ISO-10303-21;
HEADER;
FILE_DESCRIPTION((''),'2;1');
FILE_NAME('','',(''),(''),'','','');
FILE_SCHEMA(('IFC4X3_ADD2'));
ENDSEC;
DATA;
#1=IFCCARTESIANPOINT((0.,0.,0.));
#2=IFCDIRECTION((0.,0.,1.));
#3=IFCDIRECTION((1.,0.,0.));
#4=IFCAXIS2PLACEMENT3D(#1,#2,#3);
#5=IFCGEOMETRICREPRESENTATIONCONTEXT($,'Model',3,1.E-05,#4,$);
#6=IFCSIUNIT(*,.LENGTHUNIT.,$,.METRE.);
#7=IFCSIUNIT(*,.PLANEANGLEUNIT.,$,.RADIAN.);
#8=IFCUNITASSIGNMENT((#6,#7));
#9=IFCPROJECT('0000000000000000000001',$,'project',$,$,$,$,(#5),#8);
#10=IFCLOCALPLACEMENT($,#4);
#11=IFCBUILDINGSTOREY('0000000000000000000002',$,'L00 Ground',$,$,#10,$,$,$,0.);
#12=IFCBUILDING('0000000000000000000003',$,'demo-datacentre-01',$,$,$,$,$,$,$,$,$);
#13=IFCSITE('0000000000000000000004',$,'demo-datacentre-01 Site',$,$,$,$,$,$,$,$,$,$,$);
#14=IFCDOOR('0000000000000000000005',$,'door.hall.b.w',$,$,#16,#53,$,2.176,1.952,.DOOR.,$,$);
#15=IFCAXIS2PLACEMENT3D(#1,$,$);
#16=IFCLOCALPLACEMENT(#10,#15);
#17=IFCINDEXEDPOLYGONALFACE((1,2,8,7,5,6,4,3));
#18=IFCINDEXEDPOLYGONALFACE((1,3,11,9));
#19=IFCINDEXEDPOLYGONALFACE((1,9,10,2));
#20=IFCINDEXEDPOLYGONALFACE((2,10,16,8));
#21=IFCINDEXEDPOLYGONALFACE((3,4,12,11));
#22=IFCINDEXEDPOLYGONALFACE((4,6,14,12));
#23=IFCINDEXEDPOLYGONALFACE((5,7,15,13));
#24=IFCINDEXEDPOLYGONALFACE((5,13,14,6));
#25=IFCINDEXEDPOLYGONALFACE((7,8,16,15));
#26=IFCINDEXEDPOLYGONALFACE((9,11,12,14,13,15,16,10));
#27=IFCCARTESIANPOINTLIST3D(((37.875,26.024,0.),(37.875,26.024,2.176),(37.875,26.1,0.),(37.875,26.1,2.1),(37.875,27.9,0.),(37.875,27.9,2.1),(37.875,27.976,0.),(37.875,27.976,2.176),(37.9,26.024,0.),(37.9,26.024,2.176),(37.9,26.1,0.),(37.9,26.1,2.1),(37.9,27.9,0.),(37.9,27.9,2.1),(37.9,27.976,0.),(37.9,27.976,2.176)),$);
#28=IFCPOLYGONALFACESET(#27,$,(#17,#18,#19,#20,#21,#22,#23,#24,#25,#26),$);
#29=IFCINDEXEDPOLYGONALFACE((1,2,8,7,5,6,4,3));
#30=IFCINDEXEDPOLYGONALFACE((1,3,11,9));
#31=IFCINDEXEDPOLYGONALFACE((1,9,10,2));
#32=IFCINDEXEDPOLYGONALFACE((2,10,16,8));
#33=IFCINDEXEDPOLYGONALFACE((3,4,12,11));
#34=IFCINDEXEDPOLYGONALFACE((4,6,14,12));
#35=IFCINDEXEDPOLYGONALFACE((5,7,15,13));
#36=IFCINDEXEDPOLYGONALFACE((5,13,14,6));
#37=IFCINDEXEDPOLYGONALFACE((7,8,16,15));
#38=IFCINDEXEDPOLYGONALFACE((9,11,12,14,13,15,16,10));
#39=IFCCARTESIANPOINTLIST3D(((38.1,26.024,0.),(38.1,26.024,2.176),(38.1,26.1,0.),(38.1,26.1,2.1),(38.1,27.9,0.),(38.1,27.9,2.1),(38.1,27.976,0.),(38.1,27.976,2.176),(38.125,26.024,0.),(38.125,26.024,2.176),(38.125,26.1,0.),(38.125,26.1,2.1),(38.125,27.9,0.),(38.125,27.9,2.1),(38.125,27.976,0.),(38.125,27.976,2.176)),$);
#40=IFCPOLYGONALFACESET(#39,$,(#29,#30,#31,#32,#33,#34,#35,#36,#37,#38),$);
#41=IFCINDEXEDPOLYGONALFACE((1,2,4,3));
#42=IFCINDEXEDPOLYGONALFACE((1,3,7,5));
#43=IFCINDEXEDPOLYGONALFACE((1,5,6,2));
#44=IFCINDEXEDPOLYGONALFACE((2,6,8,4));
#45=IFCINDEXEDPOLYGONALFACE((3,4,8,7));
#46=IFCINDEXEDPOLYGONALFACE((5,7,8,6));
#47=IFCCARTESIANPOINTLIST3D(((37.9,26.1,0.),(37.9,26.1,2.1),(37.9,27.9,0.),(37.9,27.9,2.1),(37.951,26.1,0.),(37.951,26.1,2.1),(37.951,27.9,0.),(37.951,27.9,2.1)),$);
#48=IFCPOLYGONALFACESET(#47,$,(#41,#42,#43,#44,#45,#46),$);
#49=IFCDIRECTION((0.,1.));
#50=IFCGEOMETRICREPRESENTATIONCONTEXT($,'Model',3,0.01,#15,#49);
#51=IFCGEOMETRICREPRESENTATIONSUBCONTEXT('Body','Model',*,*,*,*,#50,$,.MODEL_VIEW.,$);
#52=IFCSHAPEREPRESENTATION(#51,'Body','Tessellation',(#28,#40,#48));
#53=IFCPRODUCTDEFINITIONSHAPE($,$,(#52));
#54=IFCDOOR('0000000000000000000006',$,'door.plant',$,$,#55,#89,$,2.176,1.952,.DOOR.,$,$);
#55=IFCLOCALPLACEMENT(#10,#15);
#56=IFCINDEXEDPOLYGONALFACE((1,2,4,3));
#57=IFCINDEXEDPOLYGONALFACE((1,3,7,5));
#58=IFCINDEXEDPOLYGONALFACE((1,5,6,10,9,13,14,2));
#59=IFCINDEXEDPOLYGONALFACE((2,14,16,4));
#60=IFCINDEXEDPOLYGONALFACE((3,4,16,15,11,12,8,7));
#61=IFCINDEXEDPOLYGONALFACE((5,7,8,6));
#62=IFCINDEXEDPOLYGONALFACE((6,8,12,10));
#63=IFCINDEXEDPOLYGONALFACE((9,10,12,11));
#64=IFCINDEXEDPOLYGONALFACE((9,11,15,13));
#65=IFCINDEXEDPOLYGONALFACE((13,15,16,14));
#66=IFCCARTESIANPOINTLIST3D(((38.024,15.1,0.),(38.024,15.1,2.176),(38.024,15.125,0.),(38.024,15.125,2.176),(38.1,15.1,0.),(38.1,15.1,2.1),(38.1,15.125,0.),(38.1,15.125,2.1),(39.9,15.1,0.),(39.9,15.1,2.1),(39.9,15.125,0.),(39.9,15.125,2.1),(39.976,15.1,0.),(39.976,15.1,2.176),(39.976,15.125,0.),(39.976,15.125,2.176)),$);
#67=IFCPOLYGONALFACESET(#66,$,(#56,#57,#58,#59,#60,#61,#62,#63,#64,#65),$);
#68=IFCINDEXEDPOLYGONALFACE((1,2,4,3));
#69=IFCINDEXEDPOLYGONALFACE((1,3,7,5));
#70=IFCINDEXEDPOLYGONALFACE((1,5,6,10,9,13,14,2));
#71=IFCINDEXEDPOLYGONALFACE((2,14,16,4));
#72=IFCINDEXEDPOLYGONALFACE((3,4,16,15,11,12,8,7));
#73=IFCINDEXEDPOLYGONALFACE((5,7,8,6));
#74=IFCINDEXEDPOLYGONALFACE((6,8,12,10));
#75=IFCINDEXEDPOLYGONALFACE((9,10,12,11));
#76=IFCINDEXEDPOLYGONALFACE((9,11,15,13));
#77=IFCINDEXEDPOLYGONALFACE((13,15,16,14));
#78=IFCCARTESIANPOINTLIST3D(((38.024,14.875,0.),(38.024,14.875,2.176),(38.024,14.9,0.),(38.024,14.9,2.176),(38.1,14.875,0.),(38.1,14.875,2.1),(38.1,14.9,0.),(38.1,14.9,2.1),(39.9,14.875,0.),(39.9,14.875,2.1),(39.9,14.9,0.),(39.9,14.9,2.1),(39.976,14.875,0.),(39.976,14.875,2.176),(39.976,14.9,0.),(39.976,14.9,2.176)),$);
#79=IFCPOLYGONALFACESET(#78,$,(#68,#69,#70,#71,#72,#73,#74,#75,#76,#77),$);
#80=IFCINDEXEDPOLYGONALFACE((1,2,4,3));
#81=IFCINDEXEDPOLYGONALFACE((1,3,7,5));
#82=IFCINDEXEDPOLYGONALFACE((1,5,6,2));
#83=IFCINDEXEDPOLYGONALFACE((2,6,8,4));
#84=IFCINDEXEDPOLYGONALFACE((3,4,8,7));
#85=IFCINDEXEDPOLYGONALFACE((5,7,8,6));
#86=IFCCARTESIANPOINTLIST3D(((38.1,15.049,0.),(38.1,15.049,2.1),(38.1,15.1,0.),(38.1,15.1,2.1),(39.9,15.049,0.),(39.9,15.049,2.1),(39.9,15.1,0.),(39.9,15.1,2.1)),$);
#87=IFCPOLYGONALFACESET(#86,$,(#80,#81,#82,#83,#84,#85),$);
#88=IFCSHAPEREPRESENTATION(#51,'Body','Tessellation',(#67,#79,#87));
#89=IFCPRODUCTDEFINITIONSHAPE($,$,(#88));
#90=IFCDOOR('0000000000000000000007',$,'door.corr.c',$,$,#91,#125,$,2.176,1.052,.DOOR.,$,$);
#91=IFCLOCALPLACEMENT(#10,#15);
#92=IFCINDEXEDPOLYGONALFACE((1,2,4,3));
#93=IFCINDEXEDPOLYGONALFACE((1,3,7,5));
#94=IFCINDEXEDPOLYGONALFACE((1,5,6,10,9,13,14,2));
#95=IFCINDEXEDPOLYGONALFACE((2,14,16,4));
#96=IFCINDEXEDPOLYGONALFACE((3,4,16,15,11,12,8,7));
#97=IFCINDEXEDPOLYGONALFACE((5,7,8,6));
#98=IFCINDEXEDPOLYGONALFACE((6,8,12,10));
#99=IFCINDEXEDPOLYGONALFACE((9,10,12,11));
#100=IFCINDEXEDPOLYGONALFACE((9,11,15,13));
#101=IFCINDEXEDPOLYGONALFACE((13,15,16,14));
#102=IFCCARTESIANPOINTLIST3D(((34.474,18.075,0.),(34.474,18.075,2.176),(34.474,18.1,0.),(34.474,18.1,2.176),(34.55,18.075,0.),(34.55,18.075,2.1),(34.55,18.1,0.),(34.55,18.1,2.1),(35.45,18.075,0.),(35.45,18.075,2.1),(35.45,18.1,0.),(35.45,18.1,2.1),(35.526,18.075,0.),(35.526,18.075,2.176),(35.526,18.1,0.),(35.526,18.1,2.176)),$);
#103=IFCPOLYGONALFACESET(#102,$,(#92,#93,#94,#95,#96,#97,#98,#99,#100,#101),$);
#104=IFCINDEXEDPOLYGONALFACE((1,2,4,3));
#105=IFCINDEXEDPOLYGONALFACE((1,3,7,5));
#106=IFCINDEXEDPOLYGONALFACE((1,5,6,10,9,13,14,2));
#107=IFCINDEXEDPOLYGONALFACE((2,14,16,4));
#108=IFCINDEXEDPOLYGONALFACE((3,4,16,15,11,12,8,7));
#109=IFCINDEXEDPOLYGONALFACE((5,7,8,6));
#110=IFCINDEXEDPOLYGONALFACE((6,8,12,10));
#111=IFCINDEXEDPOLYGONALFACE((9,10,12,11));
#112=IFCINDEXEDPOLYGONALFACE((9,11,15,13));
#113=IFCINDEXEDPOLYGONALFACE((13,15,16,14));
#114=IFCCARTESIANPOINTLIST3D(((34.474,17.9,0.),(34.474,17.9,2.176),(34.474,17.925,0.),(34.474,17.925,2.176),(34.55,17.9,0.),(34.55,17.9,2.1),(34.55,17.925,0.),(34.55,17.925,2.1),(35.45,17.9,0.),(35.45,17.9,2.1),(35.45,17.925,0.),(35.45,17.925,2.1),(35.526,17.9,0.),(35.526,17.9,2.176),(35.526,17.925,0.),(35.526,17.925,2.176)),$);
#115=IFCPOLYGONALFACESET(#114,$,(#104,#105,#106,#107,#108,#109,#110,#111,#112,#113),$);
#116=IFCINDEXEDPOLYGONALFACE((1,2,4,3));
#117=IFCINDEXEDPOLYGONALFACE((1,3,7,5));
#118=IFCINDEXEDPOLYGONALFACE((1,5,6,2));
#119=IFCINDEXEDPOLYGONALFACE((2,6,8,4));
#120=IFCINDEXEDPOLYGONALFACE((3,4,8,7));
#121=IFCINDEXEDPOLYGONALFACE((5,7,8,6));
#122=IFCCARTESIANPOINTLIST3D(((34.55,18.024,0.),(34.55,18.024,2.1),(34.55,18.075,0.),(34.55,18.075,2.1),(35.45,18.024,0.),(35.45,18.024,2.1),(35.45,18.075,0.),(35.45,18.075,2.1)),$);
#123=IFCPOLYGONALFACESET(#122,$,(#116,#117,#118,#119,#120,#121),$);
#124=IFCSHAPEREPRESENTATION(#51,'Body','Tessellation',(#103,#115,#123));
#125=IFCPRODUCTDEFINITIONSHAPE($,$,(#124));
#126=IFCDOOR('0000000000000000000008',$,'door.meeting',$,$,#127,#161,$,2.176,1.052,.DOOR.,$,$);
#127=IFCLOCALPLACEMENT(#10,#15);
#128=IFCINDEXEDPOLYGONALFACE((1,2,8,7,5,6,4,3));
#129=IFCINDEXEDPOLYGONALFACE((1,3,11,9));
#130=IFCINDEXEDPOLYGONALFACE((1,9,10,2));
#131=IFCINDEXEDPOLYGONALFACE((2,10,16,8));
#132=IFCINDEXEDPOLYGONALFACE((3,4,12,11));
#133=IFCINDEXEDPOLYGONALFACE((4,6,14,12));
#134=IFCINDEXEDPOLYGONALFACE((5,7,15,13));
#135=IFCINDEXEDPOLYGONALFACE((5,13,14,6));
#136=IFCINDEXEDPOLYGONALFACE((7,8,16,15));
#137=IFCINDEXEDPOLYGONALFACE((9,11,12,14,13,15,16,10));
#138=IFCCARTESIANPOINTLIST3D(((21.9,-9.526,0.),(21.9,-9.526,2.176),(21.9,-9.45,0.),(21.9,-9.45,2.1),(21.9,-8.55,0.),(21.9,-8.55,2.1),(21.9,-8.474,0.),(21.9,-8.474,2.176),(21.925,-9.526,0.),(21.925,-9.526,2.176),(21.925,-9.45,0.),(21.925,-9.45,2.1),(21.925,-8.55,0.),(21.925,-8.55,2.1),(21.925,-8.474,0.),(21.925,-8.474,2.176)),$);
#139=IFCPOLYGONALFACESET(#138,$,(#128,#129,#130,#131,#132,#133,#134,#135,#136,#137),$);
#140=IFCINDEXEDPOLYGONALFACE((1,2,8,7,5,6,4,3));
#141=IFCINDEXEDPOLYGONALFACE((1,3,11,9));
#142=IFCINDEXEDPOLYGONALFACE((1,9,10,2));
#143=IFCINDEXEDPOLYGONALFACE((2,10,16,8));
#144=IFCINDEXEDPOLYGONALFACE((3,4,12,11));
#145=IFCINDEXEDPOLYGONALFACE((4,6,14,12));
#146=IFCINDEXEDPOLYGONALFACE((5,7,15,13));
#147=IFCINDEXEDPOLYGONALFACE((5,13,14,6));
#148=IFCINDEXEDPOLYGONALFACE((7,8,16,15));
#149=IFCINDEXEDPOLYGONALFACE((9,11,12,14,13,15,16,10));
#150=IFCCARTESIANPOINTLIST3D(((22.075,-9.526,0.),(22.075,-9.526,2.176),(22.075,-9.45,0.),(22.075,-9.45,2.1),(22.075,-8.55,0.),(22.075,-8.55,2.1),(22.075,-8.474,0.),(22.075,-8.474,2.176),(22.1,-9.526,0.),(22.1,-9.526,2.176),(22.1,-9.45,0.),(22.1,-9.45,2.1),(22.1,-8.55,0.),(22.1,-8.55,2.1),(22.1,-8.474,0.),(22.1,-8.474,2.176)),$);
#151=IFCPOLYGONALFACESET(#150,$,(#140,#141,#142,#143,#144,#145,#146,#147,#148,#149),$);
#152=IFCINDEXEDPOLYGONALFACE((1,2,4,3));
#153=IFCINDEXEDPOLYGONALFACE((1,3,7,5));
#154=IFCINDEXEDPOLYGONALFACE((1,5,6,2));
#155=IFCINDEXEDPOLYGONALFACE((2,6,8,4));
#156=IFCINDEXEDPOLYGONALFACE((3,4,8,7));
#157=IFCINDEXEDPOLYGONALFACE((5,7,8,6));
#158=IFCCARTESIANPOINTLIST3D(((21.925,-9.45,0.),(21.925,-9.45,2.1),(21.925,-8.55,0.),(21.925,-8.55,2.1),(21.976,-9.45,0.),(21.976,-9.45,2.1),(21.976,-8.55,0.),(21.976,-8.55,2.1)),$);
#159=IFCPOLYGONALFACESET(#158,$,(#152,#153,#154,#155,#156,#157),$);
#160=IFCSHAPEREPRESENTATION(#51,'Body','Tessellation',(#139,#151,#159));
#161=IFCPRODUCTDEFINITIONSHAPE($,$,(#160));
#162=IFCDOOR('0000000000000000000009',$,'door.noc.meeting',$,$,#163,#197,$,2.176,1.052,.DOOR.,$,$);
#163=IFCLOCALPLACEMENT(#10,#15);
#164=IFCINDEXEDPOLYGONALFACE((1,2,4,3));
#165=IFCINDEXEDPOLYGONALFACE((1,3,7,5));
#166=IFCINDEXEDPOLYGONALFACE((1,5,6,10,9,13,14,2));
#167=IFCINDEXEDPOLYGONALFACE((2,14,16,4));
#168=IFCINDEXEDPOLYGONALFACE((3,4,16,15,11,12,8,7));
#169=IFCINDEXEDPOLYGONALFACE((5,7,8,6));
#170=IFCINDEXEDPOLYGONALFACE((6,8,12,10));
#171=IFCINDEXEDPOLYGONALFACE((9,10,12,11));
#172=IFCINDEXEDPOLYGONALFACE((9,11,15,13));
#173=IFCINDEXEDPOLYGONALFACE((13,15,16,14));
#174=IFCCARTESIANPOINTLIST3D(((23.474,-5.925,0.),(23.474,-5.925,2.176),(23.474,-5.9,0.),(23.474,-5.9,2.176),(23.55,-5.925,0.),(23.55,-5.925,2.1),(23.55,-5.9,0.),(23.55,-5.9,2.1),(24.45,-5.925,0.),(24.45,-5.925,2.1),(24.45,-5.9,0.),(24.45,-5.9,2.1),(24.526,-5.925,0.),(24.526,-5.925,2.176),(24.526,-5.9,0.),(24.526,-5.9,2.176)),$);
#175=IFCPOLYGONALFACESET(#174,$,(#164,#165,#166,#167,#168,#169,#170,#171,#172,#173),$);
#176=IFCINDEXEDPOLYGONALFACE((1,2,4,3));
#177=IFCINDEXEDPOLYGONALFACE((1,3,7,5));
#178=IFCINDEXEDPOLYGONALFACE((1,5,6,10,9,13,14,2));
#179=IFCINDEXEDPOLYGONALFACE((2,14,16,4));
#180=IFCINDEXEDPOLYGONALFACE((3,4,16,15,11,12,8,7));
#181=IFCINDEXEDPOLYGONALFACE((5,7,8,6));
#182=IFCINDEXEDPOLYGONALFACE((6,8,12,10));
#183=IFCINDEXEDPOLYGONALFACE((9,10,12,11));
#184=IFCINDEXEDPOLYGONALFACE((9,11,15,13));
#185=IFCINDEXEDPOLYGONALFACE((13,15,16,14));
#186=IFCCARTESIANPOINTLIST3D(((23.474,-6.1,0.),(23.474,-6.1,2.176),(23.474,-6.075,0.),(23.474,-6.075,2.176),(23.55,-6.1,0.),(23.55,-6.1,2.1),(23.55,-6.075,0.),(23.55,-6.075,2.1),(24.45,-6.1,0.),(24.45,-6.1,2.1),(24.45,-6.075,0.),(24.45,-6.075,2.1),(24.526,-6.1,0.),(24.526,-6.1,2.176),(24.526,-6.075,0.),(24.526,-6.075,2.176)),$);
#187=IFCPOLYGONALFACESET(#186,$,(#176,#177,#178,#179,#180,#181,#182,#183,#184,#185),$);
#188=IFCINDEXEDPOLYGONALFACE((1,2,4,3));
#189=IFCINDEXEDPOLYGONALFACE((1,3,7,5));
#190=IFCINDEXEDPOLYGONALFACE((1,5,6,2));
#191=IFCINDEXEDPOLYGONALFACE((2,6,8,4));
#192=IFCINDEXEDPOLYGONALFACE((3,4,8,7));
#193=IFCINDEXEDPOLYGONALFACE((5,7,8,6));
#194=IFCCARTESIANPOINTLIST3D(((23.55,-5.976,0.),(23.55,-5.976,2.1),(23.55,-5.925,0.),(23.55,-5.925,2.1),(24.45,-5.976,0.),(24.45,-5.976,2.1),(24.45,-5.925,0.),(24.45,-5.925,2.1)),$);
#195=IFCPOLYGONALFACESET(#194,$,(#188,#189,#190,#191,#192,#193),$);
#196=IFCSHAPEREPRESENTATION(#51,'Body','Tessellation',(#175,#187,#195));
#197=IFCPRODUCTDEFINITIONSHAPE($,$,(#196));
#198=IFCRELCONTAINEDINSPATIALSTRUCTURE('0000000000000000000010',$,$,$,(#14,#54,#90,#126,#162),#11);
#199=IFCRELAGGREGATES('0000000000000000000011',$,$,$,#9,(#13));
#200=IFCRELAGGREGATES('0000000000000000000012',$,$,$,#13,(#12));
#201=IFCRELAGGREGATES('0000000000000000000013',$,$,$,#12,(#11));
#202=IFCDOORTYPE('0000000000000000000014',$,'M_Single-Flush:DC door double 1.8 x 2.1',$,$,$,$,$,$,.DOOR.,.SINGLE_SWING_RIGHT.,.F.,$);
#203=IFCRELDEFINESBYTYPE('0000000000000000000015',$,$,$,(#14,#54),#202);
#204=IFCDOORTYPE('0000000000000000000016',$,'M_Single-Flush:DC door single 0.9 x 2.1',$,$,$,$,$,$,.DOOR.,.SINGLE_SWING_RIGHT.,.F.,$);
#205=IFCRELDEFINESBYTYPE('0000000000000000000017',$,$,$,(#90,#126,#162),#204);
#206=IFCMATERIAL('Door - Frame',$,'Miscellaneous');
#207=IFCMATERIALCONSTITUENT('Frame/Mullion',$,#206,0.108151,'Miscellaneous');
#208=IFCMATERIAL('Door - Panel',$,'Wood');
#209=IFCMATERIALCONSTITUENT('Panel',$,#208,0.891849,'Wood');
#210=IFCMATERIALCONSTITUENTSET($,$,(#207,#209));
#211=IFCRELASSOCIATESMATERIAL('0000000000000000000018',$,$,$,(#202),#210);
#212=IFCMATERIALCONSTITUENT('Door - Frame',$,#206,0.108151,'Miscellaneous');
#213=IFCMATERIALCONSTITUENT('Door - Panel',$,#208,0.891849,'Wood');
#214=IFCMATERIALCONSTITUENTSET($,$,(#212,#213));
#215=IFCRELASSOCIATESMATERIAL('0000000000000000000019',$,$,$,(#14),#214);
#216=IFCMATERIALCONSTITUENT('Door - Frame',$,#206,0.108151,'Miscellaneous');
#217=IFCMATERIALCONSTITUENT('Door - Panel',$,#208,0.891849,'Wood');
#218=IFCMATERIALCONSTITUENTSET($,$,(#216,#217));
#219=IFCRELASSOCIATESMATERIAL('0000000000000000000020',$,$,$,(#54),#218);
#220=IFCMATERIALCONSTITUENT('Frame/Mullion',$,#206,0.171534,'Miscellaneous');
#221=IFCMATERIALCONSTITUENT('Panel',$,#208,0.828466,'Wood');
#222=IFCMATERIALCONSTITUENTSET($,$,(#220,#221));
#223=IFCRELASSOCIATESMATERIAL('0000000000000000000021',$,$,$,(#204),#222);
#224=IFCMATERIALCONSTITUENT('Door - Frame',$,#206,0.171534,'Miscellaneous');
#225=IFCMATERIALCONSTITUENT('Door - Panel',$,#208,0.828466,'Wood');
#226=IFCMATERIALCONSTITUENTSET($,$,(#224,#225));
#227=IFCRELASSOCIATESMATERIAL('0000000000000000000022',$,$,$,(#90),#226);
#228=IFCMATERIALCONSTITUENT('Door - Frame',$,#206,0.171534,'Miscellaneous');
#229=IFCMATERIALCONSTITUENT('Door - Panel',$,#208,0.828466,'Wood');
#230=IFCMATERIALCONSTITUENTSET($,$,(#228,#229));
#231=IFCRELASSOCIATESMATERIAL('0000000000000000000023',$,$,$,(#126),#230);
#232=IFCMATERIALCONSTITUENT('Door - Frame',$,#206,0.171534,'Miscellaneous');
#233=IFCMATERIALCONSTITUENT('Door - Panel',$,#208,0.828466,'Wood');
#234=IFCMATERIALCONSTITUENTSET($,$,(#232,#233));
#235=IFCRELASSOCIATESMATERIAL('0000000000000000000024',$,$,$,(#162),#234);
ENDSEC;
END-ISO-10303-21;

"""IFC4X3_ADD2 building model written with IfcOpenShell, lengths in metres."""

from ifc_helpers import new_model, si_unit, direction, frame, frame_2d, origin, origin_with_axes, place, context, subcontext, project, spatial, polyline, rectangle, outline, extrude, source, transform, mapped, material, constituent, constituent_set, type_object, type_shapes, element, save


model = new_model("IFC4X3_ADD2")

# Units and contexts
model_context_1 = context("Model", 3, precision=0.01, world=origin(), true_north=direction((0.0, 1.0)))
model_context_2 = context("Model", 3, precision=1e-05, world=origin_with_axes())
body_context = subcontext(model_context_1, "Body", "Model", "MODEL_VIEW")
ifc_project = project(units=[si_unit("LENGTHUNIT", "METRE"), si_unit("PLANEANGLEUNIT", "RADIAN")], contexts=[model_context_2])

# Site, building, storey
site = spatial("IfcSite", under=ifc_project, Name="demo-datacentre-01 Site")
building = spatial("IfcBuilding", under=site, Name="demo-datacentre-01")
storey_placement = place(None, origin_with_axes())
storey = spatial("IfcBuildingStorey", under=building, at=storey_placement, Name="L00 Ground", Elevation=0.0)

# Shared definitions
placement_1 = place(None, origin())
placement_2 = place(placement_1, origin())
placement_3 = place(placement_2, origin())

# Doors
ifc_material_1 = material(Name="Door - Frame", Category="Miscellaneous")
ifc_material_2 = material(Name="Door - Panel", Category="Wood")
ifc_constituent_1 = constituent(ifc_material_1, Name="Frame/Mullion", Category="Miscellaneous", fraction=0.108151)
ifc_constituent_2 = constituent(ifc_material_2, Name="Panel", Category="Wood", fraction=0.891849)
ifc_constituent_set_1 = constituent_set(constituents=[ifc_constituent_1, ifc_constituent_2])
door_type_1 = type_object("IfcDoorType", Name="M_Single-Flush:DC door double 1.8 x 2.1", OperationType="SINGLE_SWING_RIGHT", ParameterTakesPrecedence=False, PredefinedType="DOOR", material=ifc_constituent_set_1)
shared_shape_1 = source(origin(), body_context, "Body", "SweptSolid", [
    extrude(outline(polyline([(-0.976, -1.107), (0.976, -1.107), (0.976, 1.069), (0.9, 1.069), (0.9, -1.031), (-0.9, -1.031), (-0.9, 1.069), (-0.976, 1.069), (-0.976, -1.107)])), frame((0.9, 0.2, 1.069), z_axis=(0.0, 1.0, 0.0), x_axis=(1.0, 0.0, 0.0)), (0.0, 0.0, 1.0), 0.025),
    extrude(outline(polyline([(-1.107, -0.976), (1.069, -0.976), (1.069, -0.9), (-1.031, -0.9), (-1.031, 0.9), (1.069, 0.9), (1.069, 0.976), (-1.107, 0.976), (-1.107, -0.976)])), frame((0.9, -0.025, 1.069), z_axis=(0.0, 1.0, 0.0), x_axis=(0.0, 0.0, -1.0)), (0.0, 0.0, 1.0), 0.025),
    extrude(rectangle(XDim=0.051, YDim=1.8, at=frame_2d((0.0, 0.0), x_axis=(1.0, 0.0))), frame((0.9, 0.1745, 0.0), z_axis=(0.0, 0.0, 1.0), x_axis=(0.0, 1.0, 0.0)), (0.0, 0.0, 1.0), 2.1),
])
type_shapes(door_type_1, [shared_shape_1])
ifc_constituent_3 = constituent(ifc_material_1, Name="Door - Frame", Category="Miscellaneous", fraction=0.108151)
ifc_constituent_4 = constituent(ifc_material_2, Name="Door - Panel", Category="Wood", fraction=0.891849)
ifc_constituent_set_2 = constituent_set(constituents=[ifc_constituent_3, ifc_constituent_4])
door_1_placement = place(placement_3, frame((38.1, 26.1, 0.0), z_axis=(0.0, 0.0, 1.0), x_axis=(0.0, 1.0, 0.0)))
element("IfcDoor", 1, at=door_1_placement, inside=storey, type_object=door_type_1, material=ifc_constituent_set_2, Name="door.hall.b.w", OverallHeight=2.176, OverallWidth=1.952, PredefinedType="DOOR", context=body_context, shape_type="MappedRepresentation", body=[
    mapped(shared_shape_1, transform((0.0, 0.0, 0.0), scale=1.0)),
])
ifc_constituent_5 = constituent(ifc_material_1, Name="Door - Frame", Category="Miscellaneous", fraction=0.108151)
ifc_constituent_6 = constituent(ifc_material_2, Name="Door - Panel", Category="Wood", fraction=0.891849)
ifc_constituent_set_3 = constituent_set(constituents=[ifc_constituent_5, ifc_constituent_6])
door_2_placement = place(placement_3, frame((38.1, 14.9, 0.0)))
element("IfcDoor", 2, at=door_2_placement, inside=storey, type_object=door_type_1, material=ifc_constituent_set_3, Name="door.plant", OverallHeight=2.176, OverallWidth=1.952, PredefinedType="DOOR", context=body_context, shape_type="MappedRepresentation", body=[
    mapped(shared_shape_1, transform((0.0, 0.0, 0.0), scale=1.0)),
])
ifc_constituent_7 = constituent(ifc_material_1, Name="Door - Frame", Category="Miscellaneous", fraction=0.171534)
ifc_constituent_8 = constituent(ifc_material_2, Name="Door - Panel", Category="Wood", fraction=0.828466)
ifc_constituent_set_4 = constituent_set(constituents=[ifc_constituent_7, ifc_constituent_8])
ifc_constituent_9 = constituent(ifc_material_1, Name="Frame/Mullion", Category="Miscellaneous", fraction=0.171534)
ifc_constituent_10 = constituent(ifc_material_2, Name="Panel", Category="Wood", fraction=0.828466)
ifc_constituent_set_5 = constituent_set(constituents=[ifc_constituent_9, ifc_constituent_10])
door_type_2 = type_object("IfcDoorType", Name="M_Single-Flush:DC door single 0.9 x 2.1", OperationType="SINGLE_SWING_RIGHT", ParameterTakesPrecedence=False, PredefinedType="DOOR", material=ifc_constituent_set_5)
shared_shape_2 = source(origin(), body_context, "Body", "SweptSolid", [
    extrude(outline(polyline([(-0.526, -1.107), (0.526, -1.107), (0.526, 1.069), (0.45, 1.069), (0.45, -1.031), (-0.45, -1.031), (-0.45, 1.069), (-0.526, 1.069), (-0.526, -1.107)])), frame((0.45, 0.15, 1.069), z_axis=(0.0, 1.0, 0.0), x_axis=(1.0, 0.0, 0.0)), (0.0, 0.0, 1.0), 0.025),
    extrude(outline(polyline([(-1.107, -0.526), (1.069, -0.526), (1.069, -0.45), (-1.031, -0.45), (-1.031, 0.45), (1.069, 0.45), (1.069, 0.526), (-1.107, 0.526), (-1.107, -0.526)])), frame((0.45, -0.025, 1.069), z_axis=(0.0, 1.0, 0.0), x_axis=(0.0, 0.0, -1.0)), (0.0, 0.0, 1.0), 0.025),
    extrude(rectangle(XDim=0.051, YDim=0.9, at=frame_2d((0.0, 0.0), x_axis=(1.0, 0.0))), frame((0.45, 0.1245, 0.0), z_axis=(0.0, 0.0, 1.0), x_axis=(0.0, 1.0, 0.0)), (0.0, 0.0, 1.0), 2.1),
])
type_shapes(door_type_2, [shared_shape_2])
door_3_placement = place(placement_3, frame((34.55, 17.925, 0.0)))
element("IfcDoor", 3, at=door_3_placement, inside=storey, type_object=door_type_2, material=ifc_constituent_set_4, Name="door.corr.c", OverallHeight=2.176, OverallWidth=1.052, PredefinedType="DOOR", context=body_context, shape_type="MappedRepresentation", body=[
    mapped(shared_shape_2, transform((0.0, 0.0, 0.0), scale=1.0)),
])
ifc_constituent_11 = constituent(ifc_material_1, Name="Door - Frame", Category="Miscellaneous", fraction=0.171534)
ifc_constituent_12 = constituent(ifc_material_2, Name="Door - Panel", Category="Wood", fraction=0.828466)
ifc_constituent_set_6 = constituent_set(constituents=[ifc_constituent_11, ifc_constituent_12])
door_4_placement = place(placement_3, frame((22.075, -9.45, 0.0), z_axis=(0.0, 0.0, 1.0), x_axis=(0.0, 1.0, 0.0)))
element("IfcDoor", 4, at=door_4_placement, inside=storey, type_object=door_type_2, material=ifc_constituent_set_6, Name="door.meeting", OverallHeight=2.176, OverallWidth=1.052, PredefinedType="DOOR", context=body_context, shape_type="MappedRepresentation", body=[
    mapped(shared_shape_2, transform((0.0, 0.0, 0.0), scale=1.0)),
])
ifc_constituent_13 = constituent(ifc_material_1, Name="Door - Frame", Category="Miscellaneous", fraction=0.171534)
ifc_constituent_14 = constituent(ifc_material_2, Name="Door - Panel", Category="Wood", fraction=0.828466)
ifc_constituent_set_7 = constituent_set(constituents=[ifc_constituent_13, ifc_constituent_14])
door_5_placement = place(placement_3, frame((23.55, -6.075, 0.0)))
element("IfcDoor", 5, at=door_5_placement, inside=storey, type_object=door_type_2, material=ifc_constituent_set_7, Name="door.noc.meeting", OverallHeight=2.176, OverallWidth=1.052, PredefinedType="DOOR", context=body_context, shape_type="MappedRepresentation", body=[
    mapped(shared_shape_2, transform((0.0, 0.0, 0.0), scale=1.0)),
])

save(model, "model.ifc")
